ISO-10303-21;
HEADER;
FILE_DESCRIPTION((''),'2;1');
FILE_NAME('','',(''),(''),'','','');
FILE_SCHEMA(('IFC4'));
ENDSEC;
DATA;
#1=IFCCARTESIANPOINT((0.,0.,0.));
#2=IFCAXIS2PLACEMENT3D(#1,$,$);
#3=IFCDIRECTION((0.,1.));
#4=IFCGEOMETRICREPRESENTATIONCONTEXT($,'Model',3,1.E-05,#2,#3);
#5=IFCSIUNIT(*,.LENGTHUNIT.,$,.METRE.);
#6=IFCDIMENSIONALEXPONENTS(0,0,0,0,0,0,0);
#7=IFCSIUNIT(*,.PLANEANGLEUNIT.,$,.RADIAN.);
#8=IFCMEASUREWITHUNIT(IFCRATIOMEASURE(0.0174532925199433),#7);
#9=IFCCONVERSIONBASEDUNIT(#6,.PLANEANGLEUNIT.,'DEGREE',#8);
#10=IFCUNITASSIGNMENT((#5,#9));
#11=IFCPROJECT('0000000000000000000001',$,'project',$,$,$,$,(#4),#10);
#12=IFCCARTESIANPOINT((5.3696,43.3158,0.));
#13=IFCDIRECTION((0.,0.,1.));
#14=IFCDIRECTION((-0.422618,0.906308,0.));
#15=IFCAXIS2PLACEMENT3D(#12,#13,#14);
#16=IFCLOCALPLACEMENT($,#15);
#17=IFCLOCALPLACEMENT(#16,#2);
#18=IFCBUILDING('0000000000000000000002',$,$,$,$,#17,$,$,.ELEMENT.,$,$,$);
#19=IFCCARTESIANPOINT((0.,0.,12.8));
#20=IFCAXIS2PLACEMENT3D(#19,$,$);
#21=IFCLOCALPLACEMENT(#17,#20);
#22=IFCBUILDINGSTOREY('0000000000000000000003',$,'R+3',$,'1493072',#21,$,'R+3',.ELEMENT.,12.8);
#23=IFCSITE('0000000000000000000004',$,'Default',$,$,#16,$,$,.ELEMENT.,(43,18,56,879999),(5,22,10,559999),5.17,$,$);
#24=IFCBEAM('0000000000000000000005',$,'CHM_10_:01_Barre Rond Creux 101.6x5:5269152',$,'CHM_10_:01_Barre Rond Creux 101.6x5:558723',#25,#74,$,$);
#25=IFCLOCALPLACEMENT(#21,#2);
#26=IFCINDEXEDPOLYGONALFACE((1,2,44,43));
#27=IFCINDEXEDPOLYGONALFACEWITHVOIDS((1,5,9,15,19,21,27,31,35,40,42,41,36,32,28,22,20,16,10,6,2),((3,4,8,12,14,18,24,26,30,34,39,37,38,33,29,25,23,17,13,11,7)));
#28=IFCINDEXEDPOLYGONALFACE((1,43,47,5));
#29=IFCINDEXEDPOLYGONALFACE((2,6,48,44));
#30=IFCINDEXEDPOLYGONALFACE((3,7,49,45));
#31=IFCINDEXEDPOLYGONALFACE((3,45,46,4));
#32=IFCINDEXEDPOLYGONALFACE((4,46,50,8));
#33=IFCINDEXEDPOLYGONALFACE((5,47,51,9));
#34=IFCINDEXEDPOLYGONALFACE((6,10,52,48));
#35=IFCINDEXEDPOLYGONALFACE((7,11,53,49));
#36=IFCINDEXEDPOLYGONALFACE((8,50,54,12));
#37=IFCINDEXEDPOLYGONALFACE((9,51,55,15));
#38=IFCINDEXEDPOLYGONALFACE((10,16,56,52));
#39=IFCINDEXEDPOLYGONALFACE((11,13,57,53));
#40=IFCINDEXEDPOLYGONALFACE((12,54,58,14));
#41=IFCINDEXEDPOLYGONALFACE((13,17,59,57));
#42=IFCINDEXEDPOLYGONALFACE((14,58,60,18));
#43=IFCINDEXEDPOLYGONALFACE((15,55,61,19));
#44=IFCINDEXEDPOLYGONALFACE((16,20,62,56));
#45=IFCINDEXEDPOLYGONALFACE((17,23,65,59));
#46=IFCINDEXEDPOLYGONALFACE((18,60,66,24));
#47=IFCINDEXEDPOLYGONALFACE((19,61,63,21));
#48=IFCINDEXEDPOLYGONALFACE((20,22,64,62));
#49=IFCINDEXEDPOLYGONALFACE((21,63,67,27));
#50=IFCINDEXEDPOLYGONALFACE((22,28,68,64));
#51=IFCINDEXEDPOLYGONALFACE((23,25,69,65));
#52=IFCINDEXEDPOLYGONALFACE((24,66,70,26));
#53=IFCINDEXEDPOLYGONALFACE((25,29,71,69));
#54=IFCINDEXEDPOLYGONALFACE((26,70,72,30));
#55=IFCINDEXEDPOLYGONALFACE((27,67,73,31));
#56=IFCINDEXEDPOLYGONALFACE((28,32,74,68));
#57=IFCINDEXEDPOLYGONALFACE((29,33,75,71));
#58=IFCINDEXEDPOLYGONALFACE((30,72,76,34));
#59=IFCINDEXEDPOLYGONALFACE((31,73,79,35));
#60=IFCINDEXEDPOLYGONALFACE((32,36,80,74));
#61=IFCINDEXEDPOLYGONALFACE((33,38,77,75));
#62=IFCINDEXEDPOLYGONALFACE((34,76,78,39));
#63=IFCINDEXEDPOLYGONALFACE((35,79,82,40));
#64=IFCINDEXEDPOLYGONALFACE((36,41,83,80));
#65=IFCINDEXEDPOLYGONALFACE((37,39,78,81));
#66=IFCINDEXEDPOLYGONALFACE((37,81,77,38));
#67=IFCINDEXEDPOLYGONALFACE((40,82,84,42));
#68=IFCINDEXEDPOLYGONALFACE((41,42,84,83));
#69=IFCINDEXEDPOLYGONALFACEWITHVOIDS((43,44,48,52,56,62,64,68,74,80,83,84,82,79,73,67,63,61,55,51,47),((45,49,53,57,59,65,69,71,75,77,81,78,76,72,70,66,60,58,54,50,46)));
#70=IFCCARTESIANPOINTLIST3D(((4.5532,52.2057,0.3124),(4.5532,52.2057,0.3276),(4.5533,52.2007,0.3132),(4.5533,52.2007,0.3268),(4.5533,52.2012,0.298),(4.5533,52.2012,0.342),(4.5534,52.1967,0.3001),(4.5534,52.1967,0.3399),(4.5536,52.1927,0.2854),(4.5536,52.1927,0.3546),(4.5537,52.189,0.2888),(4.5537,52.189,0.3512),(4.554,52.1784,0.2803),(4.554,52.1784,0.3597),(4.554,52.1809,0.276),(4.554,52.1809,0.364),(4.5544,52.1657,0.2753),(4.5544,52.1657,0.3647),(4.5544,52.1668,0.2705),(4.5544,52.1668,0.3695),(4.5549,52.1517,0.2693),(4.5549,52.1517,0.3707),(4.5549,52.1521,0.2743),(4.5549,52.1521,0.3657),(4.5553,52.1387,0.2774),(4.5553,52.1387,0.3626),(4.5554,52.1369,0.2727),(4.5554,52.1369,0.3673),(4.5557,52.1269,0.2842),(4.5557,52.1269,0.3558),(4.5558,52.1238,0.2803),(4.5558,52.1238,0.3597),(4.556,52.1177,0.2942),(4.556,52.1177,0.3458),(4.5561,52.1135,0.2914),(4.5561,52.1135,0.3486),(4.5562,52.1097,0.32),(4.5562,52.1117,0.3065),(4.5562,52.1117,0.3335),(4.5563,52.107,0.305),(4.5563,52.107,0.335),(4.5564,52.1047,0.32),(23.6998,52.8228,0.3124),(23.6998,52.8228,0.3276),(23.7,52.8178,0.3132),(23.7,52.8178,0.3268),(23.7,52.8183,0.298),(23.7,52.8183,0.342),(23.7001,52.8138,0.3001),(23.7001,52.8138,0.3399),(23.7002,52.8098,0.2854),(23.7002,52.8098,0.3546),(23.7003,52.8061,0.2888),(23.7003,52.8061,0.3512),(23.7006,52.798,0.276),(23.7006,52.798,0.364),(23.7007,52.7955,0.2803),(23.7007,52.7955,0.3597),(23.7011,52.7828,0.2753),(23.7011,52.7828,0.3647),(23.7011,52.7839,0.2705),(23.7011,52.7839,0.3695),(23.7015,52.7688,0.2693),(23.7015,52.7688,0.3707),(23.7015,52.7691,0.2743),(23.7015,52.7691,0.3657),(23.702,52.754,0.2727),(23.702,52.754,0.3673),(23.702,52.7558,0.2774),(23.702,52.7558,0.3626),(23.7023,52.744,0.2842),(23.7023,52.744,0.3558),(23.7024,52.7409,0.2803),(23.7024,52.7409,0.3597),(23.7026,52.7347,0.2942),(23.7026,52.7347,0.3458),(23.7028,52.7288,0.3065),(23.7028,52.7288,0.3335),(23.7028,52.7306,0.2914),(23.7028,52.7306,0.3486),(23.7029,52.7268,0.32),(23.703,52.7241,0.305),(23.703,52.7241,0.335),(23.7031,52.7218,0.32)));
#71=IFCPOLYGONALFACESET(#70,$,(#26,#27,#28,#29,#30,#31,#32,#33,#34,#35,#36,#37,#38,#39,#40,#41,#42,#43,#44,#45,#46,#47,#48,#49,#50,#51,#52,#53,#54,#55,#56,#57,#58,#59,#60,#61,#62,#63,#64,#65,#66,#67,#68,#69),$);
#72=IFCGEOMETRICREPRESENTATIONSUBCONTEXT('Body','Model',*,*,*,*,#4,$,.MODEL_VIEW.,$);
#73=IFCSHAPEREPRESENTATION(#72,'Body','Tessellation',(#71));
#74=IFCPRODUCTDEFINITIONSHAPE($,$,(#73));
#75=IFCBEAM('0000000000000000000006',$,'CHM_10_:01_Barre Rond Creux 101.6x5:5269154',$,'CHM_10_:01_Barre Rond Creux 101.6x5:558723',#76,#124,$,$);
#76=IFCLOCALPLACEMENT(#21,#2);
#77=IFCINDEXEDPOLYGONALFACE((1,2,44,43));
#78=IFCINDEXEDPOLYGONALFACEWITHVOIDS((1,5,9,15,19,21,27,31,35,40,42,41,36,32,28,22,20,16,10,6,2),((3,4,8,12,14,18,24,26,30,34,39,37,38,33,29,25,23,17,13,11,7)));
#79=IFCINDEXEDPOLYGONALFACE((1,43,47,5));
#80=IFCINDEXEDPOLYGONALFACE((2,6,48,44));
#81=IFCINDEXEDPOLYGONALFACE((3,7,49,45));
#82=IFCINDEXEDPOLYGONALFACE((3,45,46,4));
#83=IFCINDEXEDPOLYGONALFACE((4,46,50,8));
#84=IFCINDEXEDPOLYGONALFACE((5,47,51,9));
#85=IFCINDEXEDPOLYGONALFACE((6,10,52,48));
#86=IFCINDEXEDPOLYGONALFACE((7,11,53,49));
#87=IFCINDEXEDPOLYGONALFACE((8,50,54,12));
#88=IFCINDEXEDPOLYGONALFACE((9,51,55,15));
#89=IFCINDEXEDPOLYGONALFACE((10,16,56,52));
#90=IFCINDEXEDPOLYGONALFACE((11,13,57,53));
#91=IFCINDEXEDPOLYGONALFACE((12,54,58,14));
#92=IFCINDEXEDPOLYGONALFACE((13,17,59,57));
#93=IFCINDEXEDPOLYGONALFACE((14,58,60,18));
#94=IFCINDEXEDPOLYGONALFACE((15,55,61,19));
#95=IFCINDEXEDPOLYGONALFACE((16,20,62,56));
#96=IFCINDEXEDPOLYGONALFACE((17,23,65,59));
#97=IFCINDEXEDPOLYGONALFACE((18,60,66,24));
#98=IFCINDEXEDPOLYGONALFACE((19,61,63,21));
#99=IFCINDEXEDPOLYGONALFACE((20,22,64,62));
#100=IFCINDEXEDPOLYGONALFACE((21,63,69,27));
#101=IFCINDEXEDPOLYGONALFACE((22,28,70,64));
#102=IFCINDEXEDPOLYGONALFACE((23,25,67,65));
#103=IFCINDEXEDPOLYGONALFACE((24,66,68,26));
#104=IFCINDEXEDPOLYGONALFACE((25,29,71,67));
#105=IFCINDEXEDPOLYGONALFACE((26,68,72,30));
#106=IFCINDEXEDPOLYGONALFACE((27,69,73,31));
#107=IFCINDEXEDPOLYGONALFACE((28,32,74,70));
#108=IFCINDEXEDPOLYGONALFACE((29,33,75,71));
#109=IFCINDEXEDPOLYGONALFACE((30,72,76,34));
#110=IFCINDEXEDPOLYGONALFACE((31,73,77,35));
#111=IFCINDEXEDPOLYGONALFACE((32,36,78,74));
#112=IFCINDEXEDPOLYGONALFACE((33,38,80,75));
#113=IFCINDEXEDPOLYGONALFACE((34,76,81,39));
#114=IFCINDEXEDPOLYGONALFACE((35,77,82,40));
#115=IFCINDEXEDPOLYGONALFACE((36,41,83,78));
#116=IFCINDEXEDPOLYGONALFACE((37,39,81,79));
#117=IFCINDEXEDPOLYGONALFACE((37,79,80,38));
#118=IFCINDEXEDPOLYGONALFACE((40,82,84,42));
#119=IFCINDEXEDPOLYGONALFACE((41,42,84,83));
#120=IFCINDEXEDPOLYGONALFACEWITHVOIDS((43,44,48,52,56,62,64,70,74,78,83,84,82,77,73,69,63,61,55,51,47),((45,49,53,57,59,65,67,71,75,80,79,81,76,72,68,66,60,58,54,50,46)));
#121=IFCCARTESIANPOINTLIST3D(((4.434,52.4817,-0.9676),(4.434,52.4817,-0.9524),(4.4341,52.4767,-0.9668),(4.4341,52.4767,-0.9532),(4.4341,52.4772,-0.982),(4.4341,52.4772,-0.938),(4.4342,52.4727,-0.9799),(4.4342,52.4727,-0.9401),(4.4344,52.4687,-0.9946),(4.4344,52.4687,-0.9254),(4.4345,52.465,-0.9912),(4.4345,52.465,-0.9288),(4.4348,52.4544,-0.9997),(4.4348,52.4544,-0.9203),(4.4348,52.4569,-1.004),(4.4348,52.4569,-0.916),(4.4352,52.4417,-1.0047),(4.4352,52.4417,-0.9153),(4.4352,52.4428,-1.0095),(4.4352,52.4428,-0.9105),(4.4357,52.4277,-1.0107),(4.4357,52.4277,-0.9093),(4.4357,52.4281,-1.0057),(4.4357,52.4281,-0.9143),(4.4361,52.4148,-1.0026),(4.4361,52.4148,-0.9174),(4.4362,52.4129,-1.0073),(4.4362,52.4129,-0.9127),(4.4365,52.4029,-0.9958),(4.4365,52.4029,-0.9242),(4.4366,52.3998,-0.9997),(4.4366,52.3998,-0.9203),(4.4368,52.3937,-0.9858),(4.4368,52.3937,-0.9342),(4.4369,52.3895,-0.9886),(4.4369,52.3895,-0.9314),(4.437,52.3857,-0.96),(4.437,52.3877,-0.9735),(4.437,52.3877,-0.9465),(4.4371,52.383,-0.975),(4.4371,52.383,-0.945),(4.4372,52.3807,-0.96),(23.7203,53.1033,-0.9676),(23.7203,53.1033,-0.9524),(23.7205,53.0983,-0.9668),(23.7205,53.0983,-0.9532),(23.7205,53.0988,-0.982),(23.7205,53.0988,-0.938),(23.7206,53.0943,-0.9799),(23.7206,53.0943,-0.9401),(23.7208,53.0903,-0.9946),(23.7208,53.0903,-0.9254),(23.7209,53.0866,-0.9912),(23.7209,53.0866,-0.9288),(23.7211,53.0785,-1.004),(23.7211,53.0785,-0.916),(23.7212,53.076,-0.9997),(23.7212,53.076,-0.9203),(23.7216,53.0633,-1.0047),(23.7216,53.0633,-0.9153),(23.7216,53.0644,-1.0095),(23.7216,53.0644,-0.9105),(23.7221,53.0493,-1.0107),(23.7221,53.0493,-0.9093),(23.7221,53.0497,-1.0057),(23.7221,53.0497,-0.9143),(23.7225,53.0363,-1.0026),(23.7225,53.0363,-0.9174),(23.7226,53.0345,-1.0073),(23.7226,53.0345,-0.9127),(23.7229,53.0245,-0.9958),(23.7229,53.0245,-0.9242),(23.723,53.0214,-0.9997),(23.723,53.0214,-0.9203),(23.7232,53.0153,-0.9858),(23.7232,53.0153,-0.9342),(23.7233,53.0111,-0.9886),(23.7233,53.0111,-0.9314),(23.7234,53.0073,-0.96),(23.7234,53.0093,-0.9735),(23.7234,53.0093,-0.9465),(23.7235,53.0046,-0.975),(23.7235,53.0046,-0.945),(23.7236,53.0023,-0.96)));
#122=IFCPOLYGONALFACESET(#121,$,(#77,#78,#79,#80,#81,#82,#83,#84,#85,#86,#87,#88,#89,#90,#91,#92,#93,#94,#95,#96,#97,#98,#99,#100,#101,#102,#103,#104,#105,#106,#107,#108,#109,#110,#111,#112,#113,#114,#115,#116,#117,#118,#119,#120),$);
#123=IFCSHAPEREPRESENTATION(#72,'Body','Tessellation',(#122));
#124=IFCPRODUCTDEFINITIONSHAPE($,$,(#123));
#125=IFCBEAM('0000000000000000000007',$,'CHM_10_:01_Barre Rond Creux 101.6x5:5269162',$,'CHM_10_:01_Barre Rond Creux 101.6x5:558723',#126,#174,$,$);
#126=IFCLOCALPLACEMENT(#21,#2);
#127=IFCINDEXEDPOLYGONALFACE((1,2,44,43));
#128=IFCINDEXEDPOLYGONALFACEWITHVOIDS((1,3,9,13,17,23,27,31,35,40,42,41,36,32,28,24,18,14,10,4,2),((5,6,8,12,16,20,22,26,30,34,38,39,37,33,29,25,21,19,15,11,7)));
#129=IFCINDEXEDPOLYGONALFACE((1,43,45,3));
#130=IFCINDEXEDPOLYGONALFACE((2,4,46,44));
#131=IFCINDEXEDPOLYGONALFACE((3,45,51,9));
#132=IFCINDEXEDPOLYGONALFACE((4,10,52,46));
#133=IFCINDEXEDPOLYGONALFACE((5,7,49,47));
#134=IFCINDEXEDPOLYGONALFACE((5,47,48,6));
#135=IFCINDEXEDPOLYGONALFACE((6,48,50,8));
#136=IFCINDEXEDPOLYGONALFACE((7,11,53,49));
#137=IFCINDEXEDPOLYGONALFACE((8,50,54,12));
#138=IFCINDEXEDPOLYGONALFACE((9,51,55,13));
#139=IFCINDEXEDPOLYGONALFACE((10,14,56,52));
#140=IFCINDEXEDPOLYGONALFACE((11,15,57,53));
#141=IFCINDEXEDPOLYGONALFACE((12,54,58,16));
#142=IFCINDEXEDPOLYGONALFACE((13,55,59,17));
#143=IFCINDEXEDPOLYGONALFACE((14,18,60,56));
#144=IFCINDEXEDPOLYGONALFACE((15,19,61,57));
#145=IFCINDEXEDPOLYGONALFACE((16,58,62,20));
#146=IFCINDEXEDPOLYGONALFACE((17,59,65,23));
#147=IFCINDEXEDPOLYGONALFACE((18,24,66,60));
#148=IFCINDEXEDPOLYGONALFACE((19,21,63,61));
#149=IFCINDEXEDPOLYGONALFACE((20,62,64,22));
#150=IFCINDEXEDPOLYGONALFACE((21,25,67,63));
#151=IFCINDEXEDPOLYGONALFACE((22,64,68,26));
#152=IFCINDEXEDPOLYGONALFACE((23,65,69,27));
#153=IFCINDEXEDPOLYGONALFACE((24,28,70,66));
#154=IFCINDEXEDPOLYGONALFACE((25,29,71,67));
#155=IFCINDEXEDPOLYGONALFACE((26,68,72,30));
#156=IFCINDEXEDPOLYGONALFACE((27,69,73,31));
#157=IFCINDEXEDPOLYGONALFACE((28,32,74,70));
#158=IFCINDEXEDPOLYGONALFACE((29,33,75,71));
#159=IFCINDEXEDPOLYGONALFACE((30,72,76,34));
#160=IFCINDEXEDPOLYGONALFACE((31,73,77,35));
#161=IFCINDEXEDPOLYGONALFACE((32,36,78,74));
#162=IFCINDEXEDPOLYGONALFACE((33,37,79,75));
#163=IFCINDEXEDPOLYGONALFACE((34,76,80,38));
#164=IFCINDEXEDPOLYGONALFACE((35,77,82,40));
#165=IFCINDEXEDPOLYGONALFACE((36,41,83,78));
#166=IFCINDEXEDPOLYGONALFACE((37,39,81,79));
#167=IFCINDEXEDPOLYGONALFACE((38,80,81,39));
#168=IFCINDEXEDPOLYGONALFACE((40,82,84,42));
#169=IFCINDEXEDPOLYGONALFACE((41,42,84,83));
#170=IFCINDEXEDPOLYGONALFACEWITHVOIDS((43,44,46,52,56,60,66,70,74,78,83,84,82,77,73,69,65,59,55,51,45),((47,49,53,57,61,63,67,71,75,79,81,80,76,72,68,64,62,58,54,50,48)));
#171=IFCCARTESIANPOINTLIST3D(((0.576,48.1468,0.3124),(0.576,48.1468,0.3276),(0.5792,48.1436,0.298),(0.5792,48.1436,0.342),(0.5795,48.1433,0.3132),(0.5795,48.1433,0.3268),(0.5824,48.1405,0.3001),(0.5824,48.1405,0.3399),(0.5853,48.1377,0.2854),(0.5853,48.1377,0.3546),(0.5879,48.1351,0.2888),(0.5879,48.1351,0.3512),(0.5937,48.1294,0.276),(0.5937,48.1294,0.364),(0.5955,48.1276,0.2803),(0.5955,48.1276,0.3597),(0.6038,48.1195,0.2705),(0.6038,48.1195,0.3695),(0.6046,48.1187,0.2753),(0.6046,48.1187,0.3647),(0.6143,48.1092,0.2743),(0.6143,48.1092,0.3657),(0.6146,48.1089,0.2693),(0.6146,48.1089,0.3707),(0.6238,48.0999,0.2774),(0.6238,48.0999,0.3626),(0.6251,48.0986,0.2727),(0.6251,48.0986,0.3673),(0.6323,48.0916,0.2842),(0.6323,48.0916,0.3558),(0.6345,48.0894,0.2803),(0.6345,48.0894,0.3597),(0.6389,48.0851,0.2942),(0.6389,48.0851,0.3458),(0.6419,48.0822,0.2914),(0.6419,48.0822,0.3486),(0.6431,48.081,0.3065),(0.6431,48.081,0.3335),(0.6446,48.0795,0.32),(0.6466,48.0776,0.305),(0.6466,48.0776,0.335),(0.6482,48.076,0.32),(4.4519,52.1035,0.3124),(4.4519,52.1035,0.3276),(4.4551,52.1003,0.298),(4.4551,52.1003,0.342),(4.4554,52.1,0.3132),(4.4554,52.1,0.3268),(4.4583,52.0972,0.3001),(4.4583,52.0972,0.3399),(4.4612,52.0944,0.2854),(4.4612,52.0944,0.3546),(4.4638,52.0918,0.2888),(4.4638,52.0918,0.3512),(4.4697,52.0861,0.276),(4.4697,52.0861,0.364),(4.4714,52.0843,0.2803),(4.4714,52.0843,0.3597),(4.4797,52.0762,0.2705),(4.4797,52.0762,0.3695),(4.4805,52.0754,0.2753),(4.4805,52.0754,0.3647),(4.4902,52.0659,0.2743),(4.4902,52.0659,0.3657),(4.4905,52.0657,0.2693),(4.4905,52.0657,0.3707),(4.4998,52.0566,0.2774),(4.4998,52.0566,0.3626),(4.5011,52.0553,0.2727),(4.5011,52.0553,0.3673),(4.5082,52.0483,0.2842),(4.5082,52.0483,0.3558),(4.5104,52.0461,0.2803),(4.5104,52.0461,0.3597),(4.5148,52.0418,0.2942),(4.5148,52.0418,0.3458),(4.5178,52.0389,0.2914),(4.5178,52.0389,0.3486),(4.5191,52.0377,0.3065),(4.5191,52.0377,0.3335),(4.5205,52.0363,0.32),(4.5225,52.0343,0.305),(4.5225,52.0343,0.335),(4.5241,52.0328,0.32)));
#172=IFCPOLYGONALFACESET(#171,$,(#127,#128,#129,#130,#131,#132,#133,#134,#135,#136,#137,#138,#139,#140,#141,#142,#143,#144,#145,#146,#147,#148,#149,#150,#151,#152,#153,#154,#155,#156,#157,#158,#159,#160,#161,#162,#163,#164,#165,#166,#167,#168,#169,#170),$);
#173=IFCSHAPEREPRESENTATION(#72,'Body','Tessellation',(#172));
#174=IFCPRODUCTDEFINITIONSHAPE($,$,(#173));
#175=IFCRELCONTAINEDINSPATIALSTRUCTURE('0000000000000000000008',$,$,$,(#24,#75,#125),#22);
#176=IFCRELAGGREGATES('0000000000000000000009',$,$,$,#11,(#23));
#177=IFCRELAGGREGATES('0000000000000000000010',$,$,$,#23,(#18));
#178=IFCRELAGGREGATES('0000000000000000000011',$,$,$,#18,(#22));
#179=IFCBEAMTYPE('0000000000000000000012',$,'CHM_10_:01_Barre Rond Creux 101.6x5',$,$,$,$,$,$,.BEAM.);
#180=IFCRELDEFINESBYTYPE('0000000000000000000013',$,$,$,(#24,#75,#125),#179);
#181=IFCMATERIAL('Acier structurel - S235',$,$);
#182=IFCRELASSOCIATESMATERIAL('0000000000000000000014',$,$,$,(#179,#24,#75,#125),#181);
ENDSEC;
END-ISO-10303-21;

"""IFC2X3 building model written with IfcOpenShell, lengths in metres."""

from ifc_helpers import new_model, entity, si_unit, converted_unit, direction, frame, origin, origin_2d_with_axis, place, context, subcontext, project, spatial, hollow_circle, extrude, material, type_object, element, save


model = new_model("IFC2X3")

# Units and contexts
model_context = context("Model", 3, precision=1e-05, world=origin(), true_north=direction((0.0, 1.0)))
body_context = subcontext(model_context, "Body", "Model", "MODEL_VIEW")
ifc_project = project(units=[si_unit("LENGTHUNIT", "METRE"), converted_unit("PLANEANGLEUNIT", "DEGREE", entity("IfcRatioMeasure", 0.0174532925199433), si_unit("PLANEANGLEUNIT", "RADIAN"), dimensions=[0, 0, 0, 0, 0, 0, 0])], contexts=[model_context])

# Site, building, storey
site_placement = place(None, frame((5.3696, 43.3158, 0.0), z_axis=(0.0, 0.0, 1.0), x_axis=(-0.422618, 0.906308, 0.0)))
site = spatial("IfcSite", under=ifc_project, at=site_placement, Name="Default", CompositionType="ELEMENT", RefLatitude=(43, 18, 56, 879999), RefLongitude=(5, 22, 10, 559999), RefElevation=5.17)
building_placement = place(site_placement, origin())
building = spatial("IfcBuilding", under=site, at=building_placement, CompositionType="ELEMENT")
storey_placement = place(building_placement, frame((0.0, 0.0, 12.8)))
storey = spatial("IfcBuildingStorey", under=building, at=storey_placement, Name="R+3", ObjectType="1493072", LongName="R+3", CompositionType="ELEMENT", Elevation=12.8)

# Shared definitions
ifc_material_1 = material(Name="Acier structurel - S235")

# Beams
beam_type_1 = type_object("IfcBeamType", Name="CHM_10_:01_Barre Rond Creux 101.6x5", PredefinedType="BEAM", material=ifc_material_1)
beam_1_placement = place(storey_placement, frame((23.6159, 52.7698, 0.32), z_axis=(0.0, 0.0, 1.0), x_axis=(-0.999481, -0.032213, 0.0)))
element("IfcBeam", 1, at=beam_1_placement, inside=storey, type_object=beam_type_1, material=ifc_material_1, Name="CHM_10_:01_Barre Rond Creux 101.6x5:5269152", ObjectType="CHM_10_:01_Barre Rond Creux 101.6x5:558723", context=body_context, shape_type="SweptSolid", body=[
    extrude(hollow_circle(Radius=0.0508, WallThickness=0.005, at=origin_2d_with_axis()), frame((-0.0856, 0.0, 0.0), z_axis=(1.0, 0.0, 0.0), x_axis=(0.0, 1.0, 0.0)), (0.0, 0.0, 1.0), 19.1566),
])
beam_2_placement = place(storey_placement, frame((23.7556, 53.0542, -0.96), z_axis=(0.0, 0.0, 1.0), x_axis=(-0.999481, -0.032213, 0.0)))
element("IfcBeam", 2, at=beam_2_placement, inside=storey, type_object=beam_type_1, material=ifc_material_1, Name="CHM_10_:01_Barre Rond Creux 101.6x5:5269154", ObjectType="CHM_10_:01_Barre Rond Creux 101.6x5:558723", context=body_context, shape_type="SweptSolid", body=[
    extrude(hollow_circle(Radius=0.0508, WallThickness=0.005, at=origin_2d_with_axis()), frame((0.0337, 0.0, 0.0), z_axis=(1.0, 0.0, 0.0), x_axis=(0.0, 1.0, 0.0)), (0.0, 0.0, 1.0), 19.2964),
])
beam_3_placement = place(storey_placement, frame((4.4994, 52.0802, 0.32), z_axis=(0.0, 0.0, 1.0), x_axis=(-0.699776, -0.714363, 0.0)))
element("IfcBeam", 3, at=beam_3_placement, inside=storey, type_object=beam_type_1, material=ifc_material_1, Name="CHM_10_:01_Barre Rond Creux 101.6x5:5269162", ObjectType="CHM_10_:01_Barre Rond Creux 101.6x5:558723", context=body_context, shape_type="SweptSolid", body=[
    extrude(hollow_circle(Radius=0.0508, WallThickness=0.005, at=origin_2d_with_axis()), frame((0.0166, 0.0, 0.0), z_axis=(1.0, 0.0, 0.0), x_axis=(0.0, 1.0, 0.0)), (0.0, 0.0, 1.0), 5.5388),
])

save(model, "model.ifc")
